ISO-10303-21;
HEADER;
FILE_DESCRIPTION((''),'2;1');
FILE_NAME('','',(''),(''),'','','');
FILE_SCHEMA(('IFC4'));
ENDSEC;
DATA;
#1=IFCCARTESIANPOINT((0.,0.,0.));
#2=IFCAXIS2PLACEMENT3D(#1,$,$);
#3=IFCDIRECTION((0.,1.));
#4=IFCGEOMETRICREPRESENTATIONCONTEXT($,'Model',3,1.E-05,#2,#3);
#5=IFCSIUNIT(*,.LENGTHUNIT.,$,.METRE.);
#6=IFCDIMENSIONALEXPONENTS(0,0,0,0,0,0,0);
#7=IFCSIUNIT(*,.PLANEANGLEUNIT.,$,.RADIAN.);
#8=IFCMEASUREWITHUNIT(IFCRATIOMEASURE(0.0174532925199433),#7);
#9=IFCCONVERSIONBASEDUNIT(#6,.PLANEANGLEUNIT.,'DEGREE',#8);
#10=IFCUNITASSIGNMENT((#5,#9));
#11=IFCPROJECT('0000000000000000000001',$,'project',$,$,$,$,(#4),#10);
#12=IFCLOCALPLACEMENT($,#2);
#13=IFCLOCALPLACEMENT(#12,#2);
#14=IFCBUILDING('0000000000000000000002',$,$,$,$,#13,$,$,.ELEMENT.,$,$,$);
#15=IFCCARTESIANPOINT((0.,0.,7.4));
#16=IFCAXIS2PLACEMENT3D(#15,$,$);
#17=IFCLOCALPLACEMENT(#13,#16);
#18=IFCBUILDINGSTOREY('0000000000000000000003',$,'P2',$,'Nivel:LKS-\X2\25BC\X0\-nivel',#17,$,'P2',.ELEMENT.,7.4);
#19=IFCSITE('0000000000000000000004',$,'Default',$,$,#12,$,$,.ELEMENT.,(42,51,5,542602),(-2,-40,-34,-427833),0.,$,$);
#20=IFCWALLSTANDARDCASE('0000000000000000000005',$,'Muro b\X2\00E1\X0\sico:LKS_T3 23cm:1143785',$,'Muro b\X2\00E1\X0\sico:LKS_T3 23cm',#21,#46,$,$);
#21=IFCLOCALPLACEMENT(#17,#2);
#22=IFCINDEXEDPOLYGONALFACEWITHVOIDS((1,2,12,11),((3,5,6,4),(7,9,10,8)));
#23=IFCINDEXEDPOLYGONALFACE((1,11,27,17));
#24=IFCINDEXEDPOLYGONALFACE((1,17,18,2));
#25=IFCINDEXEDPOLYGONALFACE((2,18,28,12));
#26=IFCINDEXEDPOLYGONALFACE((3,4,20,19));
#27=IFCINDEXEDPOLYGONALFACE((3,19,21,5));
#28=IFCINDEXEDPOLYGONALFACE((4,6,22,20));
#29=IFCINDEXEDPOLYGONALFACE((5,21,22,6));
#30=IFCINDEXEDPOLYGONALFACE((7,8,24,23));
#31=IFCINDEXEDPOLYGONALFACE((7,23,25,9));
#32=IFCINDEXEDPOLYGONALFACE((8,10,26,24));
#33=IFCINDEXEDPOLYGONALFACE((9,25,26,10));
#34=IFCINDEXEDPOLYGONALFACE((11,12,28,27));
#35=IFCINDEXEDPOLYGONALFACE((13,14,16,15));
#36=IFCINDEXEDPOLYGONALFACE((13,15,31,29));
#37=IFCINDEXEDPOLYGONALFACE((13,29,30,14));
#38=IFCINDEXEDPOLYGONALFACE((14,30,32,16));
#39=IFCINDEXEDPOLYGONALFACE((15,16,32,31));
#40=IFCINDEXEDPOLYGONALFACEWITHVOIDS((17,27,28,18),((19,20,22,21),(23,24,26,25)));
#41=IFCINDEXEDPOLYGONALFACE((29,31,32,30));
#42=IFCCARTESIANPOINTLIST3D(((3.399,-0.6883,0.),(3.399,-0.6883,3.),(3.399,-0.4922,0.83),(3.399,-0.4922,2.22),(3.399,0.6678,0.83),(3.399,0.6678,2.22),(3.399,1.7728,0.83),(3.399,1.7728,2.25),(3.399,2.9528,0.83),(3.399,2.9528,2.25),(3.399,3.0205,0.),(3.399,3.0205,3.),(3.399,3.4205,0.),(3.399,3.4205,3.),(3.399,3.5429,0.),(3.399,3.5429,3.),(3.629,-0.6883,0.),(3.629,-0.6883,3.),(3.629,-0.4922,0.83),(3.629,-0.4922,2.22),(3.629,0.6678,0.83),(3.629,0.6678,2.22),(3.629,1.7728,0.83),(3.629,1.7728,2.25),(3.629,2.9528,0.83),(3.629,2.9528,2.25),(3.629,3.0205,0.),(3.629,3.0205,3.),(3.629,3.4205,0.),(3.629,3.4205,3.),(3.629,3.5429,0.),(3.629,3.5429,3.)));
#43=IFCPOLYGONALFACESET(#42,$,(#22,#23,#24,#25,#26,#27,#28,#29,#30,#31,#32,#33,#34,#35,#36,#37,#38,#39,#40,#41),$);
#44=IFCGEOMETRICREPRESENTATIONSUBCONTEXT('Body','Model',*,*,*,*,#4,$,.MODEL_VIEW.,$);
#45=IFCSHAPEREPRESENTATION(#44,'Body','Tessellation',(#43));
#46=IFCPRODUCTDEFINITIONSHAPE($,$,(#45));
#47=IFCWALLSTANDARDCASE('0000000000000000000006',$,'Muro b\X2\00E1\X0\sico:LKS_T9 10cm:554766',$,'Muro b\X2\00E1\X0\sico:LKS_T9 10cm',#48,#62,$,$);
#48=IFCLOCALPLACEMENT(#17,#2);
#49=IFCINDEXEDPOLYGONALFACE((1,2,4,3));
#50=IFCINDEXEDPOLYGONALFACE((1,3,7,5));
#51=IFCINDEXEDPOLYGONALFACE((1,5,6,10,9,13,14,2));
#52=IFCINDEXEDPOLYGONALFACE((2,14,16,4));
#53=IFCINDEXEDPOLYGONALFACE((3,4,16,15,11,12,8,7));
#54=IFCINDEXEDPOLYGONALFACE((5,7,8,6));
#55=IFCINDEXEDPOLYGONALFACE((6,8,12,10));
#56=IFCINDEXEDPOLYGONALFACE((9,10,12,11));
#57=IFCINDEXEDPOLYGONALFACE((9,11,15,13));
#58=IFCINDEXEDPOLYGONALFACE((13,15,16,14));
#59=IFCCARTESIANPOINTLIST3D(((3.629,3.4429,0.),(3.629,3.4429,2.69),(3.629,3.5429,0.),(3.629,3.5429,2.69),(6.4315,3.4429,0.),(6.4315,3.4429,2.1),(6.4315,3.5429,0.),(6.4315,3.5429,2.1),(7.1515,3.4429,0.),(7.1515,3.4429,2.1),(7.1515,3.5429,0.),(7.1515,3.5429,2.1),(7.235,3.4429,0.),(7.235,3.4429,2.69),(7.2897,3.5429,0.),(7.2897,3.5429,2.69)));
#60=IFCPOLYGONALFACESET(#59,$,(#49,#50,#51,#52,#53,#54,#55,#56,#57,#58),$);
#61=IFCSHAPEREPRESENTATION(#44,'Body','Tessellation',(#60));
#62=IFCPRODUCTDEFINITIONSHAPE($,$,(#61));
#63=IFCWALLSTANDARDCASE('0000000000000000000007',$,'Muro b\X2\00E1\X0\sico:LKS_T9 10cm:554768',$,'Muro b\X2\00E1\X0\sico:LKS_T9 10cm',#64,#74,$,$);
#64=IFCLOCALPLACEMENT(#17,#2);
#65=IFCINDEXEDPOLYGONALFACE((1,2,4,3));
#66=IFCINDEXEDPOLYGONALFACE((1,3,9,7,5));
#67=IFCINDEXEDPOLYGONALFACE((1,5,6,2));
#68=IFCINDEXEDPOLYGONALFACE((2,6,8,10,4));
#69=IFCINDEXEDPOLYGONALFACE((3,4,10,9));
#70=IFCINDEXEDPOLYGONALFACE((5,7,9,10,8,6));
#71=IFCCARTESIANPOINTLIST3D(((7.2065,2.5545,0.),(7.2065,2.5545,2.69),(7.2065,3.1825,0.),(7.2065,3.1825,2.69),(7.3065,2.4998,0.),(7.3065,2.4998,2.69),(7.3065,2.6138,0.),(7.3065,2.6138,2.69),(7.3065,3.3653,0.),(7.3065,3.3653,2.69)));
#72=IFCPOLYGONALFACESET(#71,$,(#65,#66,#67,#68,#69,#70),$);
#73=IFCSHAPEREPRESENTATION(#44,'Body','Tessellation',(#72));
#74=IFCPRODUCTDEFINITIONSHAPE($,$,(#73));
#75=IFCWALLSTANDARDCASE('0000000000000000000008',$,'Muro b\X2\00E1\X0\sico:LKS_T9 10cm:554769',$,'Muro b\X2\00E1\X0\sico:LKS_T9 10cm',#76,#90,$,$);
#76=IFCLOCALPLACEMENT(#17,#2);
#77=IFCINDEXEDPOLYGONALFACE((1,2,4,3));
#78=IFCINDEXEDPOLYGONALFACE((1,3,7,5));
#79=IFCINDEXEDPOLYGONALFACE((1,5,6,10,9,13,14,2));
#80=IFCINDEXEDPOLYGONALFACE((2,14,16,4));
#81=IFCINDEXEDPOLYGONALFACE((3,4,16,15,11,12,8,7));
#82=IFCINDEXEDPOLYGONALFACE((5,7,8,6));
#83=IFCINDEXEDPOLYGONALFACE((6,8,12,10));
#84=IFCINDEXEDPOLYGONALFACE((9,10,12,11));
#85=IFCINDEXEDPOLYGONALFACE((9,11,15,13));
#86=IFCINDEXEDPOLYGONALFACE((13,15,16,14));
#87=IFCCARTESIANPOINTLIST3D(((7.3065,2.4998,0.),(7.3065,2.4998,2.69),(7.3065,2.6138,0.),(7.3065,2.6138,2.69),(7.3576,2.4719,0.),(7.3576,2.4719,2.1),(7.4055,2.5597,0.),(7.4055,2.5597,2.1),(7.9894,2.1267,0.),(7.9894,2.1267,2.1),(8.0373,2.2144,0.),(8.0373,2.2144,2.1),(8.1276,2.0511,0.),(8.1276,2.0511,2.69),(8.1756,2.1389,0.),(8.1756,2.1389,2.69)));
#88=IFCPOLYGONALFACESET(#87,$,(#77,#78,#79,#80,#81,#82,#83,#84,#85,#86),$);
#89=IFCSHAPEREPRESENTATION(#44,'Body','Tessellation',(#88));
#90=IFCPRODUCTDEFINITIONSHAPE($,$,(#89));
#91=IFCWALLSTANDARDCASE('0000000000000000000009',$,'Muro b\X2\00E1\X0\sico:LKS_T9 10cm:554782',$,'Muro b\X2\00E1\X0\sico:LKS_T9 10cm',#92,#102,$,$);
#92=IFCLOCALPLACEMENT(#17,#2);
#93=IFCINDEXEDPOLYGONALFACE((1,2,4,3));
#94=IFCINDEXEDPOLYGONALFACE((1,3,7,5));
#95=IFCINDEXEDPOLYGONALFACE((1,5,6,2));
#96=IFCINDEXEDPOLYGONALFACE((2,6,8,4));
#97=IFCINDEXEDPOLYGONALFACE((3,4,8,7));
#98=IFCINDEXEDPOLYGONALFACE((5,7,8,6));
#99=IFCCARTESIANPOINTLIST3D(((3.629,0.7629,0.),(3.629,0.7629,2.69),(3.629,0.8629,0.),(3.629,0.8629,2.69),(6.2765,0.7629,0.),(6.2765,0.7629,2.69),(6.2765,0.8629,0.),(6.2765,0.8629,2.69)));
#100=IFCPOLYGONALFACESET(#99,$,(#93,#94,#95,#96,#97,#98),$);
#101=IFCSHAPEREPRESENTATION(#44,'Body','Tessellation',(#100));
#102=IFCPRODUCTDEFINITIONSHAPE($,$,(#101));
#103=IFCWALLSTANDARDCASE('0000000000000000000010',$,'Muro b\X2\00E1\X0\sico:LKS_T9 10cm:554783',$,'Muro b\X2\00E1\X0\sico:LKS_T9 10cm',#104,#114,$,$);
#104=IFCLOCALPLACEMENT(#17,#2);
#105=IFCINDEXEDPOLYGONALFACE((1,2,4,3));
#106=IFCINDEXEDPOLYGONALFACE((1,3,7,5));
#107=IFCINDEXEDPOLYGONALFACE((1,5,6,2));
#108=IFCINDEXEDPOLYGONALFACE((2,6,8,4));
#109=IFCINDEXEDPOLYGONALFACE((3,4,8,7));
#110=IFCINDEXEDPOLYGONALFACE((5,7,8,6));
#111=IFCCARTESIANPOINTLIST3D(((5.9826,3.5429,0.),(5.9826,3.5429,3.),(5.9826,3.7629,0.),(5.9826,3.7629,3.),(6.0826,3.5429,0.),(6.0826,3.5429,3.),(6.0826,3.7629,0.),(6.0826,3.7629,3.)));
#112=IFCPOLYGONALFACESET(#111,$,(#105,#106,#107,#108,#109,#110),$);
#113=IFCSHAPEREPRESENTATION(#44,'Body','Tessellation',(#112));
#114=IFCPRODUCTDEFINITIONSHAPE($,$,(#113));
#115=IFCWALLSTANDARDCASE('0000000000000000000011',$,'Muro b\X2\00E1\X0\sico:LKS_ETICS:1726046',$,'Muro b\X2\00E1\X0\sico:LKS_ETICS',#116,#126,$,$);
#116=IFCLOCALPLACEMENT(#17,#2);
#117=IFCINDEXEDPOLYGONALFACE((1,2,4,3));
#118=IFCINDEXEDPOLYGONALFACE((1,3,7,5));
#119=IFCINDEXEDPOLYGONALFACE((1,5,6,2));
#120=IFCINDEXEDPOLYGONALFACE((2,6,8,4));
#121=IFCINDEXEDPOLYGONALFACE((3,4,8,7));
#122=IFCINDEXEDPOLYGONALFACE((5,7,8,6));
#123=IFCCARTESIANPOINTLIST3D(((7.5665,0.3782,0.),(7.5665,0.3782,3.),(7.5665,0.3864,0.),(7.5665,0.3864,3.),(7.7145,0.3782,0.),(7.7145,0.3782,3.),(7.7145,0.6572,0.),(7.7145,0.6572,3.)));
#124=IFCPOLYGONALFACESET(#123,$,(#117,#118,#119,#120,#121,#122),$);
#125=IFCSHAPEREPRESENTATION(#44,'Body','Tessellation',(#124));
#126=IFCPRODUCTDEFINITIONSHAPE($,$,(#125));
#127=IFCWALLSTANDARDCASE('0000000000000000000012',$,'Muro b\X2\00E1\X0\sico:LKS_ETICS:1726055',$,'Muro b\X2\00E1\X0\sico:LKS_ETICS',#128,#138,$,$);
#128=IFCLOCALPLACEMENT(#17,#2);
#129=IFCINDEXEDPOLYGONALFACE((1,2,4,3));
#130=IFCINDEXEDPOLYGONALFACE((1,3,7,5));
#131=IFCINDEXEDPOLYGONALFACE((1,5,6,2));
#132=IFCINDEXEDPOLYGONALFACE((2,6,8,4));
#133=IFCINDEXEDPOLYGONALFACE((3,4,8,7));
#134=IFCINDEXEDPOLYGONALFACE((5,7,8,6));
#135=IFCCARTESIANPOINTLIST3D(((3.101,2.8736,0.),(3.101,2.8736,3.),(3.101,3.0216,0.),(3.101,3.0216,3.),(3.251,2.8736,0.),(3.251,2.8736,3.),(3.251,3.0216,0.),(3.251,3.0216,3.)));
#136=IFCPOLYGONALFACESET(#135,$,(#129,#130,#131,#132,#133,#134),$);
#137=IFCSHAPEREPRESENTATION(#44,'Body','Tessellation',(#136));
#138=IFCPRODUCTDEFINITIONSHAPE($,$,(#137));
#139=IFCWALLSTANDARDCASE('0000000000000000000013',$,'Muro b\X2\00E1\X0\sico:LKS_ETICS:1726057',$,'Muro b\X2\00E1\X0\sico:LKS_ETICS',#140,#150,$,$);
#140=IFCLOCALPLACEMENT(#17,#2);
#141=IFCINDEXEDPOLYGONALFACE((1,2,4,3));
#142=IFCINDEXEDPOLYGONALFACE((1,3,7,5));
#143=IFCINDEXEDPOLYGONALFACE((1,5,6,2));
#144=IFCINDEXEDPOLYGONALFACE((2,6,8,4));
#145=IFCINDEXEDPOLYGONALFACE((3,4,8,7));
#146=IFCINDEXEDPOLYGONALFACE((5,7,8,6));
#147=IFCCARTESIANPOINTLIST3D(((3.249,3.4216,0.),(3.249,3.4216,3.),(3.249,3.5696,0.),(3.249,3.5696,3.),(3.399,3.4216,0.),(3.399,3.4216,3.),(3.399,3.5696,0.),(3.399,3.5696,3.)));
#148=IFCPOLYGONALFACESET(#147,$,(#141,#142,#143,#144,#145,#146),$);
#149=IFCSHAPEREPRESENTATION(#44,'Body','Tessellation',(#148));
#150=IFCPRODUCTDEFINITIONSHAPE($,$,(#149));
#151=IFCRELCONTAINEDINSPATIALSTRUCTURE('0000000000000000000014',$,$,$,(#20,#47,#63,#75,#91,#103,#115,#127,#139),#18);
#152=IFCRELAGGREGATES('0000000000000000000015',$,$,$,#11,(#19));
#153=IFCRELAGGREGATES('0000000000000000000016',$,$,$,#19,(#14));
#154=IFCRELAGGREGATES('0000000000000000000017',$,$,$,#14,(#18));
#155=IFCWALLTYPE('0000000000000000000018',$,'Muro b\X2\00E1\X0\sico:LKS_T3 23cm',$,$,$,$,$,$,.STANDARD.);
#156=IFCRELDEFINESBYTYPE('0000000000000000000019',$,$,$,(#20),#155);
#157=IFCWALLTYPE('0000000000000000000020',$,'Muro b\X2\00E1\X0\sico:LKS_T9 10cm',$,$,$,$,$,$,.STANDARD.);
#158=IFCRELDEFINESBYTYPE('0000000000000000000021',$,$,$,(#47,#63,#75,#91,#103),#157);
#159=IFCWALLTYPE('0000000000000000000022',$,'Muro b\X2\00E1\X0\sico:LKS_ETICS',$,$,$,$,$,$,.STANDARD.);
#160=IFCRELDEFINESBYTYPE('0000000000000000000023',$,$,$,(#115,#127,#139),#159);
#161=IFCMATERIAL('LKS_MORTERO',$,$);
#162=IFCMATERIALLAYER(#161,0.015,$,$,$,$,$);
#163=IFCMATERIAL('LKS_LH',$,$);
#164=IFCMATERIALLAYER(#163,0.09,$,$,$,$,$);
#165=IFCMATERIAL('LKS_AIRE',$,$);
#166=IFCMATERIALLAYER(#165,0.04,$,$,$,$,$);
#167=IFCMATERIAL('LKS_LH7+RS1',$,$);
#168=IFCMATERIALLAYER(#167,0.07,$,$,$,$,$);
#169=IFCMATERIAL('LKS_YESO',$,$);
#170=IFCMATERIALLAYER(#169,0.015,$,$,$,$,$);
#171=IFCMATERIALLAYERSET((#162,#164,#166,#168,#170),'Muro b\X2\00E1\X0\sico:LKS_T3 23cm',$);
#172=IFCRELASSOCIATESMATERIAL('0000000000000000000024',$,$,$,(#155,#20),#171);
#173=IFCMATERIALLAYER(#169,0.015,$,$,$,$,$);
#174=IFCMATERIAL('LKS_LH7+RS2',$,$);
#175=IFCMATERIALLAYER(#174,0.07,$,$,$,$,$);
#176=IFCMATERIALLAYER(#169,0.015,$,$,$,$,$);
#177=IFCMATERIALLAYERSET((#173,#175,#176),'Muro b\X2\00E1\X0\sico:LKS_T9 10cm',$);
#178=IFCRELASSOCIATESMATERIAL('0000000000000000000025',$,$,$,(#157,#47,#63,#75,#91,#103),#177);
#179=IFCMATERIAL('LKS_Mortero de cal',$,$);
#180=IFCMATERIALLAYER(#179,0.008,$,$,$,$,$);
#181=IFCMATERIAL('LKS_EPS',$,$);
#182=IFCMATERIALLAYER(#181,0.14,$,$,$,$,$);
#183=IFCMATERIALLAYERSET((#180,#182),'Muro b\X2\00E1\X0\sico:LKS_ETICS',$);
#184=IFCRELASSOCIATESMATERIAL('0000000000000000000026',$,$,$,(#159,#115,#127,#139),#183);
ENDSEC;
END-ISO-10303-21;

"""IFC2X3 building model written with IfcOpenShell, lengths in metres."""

from ifc_helpers import new_model, entity, si_unit, converted_unit, direction, frame, frame_2d, origin, place, context, subcontext, project, spatial, polyline, rectangle, outline, extrude, material, layer, layer_set, layer_usage, type_object, element, save


model = new_model("IFC2X3")

# Units and contexts
model_context = context("Model", 3, precision=1e-05, world=origin(), true_north=direction((0.0, 1.0)))
body_context = subcontext(model_context, "Body", "Model", "MODEL_VIEW")
ifc_project = project(units=[si_unit("LENGTHUNIT", "METRE"), converted_unit("PLANEANGLEUNIT", "DEGREE", entity("IfcRatioMeasure", 0.0174532925199433), si_unit("PLANEANGLEUNIT", "RADIAN"), dimensions=[0, 0, 0, 0, 0, 0, 0])], contexts=[model_context])

# Site, building, storey
site_placement = place(None, origin())
site = spatial("IfcSite", under=ifc_project, at=site_placement, Name="Default", CompositionType="ELEMENT", RefLatitude=(42, 51, 5, 542602), RefLongitude=(-2, -40, -34, -427833), RefElevation=0.0)
building_placement = place(site_placement, origin())
building = spatial("IfcBuilding", under=site, at=building_placement, CompositionType="ELEMENT")
storey_placement = place(building_placement, frame((0.0, 0.0, 7.4)))
storey = spatial("IfcBuildingStorey", under=building, at=storey_placement, Name="P2", ObjectType="Nivel:LKS-▼-nivel", LongName="P2", CompositionType="ELEMENT", Elevation=7.4)

# Shared definitions
ifc_material_1 = material(Name="LKS_MORTERO")

# Wall, openings
ifc_layer_1 = layer(ifc_material_1, 0.015)
ifc_material_2 = material(Name="LKS_LH")
ifc_layer_2 = layer(ifc_material_2, 0.09)
ifc_material_3 = material(Name="LKS_AIRE")
ifc_layer_3 = layer(ifc_material_3, 0.04)
ifc_material_4 = material(Name="LKS_LH7+RS1")
ifc_layer_4 = layer(ifc_material_4, 0.07)
ifc_material_5 = material(Name="LKS_YESO")
ifc_layer_5 = layer(ifc_material_5, 0.015)
ifc_layer_set_1 = layer_set([ifc_layer_1, ifc_layer_2, ifc_layer_3, ifc_layer_4, ifc_layer_5], Name="Muro básico:LKS_T3 23cm")
ifc_layer_usage_1 = layer_usage(ifc_layer_set_1, "AXIS2", "POSITIVE", -0.115)
wall_type_1 = type_object("IfcWallType", Name="Muro básico:LKS_T3 23cm", PredefinedType="STANDARD", material=ifc_layer_set_1)
wall_1_placement = place(storey_placement, frame((3.514, 3.5429, 0.0), z_axis=(0.0, 0.0, 1.0), x_axis=(0.0, -1.0, 0.0)))
wall_1 = element("IfcWallStandardCase", 1, at=wall_1_placement, inside=storey, type_object=wall_type_1, material=ifc_layer_usage_1, Name="Muro básico:LKS_T3 23cm:1143785", ObjectType="Muro básico:LKS_T3 23cm", context=body_context, shape_type="SweptSolid", body=[
    extrude(rectangle(XDim=4.2311, YDim=0.23, at=frame_2d((2.1156, 0.0), x_axis=(-1.0, 0.0))), origin(), (0.0, 0.0, 1.0), 3.0),
])
opening_1_placement = place(storey_placement, frame((3.514, 3.5429, 0.0), z_axis=(0.0, 0.0, 1.0), x_axis=(0.0, -1.0, 0.0)))
element("IfcOpeningElement", 2, at=opening_1_placement, cuts=wall_1, ObjectType="Opening", context=body_context, shape_type="SweptSolid", body=[
    extrude(rectangle(XDim=3.0, YDim=0.23, at=frame_2d((-0.3, 0.013), x_axis=(1.0, 0.0))), frame((0.5224, -0.013, 1.8), z_axis=(-1.0, 0.0, 0.0), x_axis=(0.0, 0.0, 1.0)), (0.0, 0.0, 1.0), 0.4),
])
opening_2_placement = place(wall_1_placement, frame((4.0351, 0.115, 0.83)))
element("IfcOpeningElement", 3, at=opening_2_placement, cuts=wall_1, ObjectType="Opening", context=body_context, shape_type="SweptSolid", body=[
    extrude(rectangle(XDim=1.39, YDim=1.16, at=frame_2d((0.695, 0.58), x_axis=(1.0, 0.0))), frame((0.0, 0.0, 0.0), z_axis=(0.0, -1.0, 0.0), x_axis=(0.0, 0.0, 1.0)), (0.0, 0.0, 1.0), 0.23),
])
opening_3_placement = place(wall_1_placement, frame((0.5901, -0.115, 0.83)))
element("IfcOpeningElement", 4, at=opening_3_placement, cuts=wall_1, ObjectType="Opening", context=body_context, shape_type="SweptSolid", body=[
    extrude(rectangle(XDim=1.42, YDim=1.18, at=frame_2d((0.71, 0.59), x_axis=(1.0, 0.0))), frame((0.0, 0.0, 0.0), z_axis=(0.0, 1.0, 0.0), x_axis=(0.0, 0.0, 1.0)), (0.0, 0.0, 1.0), 0.23),
])

# Wall, opening
ifc_layer_6 = layer(ifc_material_5, 0.015)
ifc_material_6 = material(Name="LKS_LH7+RS2")
ifc_layer_7 = layer(ifc_material_6, 0.07)
ifc_layer_8 = layer(ifc_material_5, 0.015)
ifc_layer_set_2 = layer_set([ifc_layer_6, ifc_layer_7, ifc_layer_8], Name="Muro básico:LKS_T9 10cm")
ifc_layer_usage_2 = layer_usage(ifc_layer_set_2, "AXIS2", "NEGATIVE", 0.05)
wall_type_2 = type_object("IfcWallType", Name="Muro básico:LKS_T9 10cm", PredefinedType="STANDARD", material=ifc_layer_set_2)
wall_2_placement = place(storey_placement, frame((7.2897, 3.4929, 0.0), z_axis=(0.0, 0.0, 1.0), x_axis=(-1.0, 0.0, 0.0)))
wall_2 = element("IfcWallStandardCase", 5, at=wall_2_placement, inside=storey, type_object=wall_type_2, material=ifc_layer_usage_2, Name="Muro básico:LKS_T9 10cm:554766", ObjectType="Muro básico:LKS_T9 10cm", context=body_context, shape_type="SweptSolid", body=[
    extrude(outline(polyline([(0.0, -0.05), (3.6608, -0.05), (3.6608, 0.05), (1.0132, 0.05), (0.9132, 0.05), (0.0547, 0.05), (0.0, -0.05)])), origin(), (0.0, 0.0, 1.0), 2.69),
])
opening_4_placement = place(wall_2_placement, frame((0.8582, 0.05, 0.0)))
element("IfcOpeningElement", 6, at=opening_4_placement, cuts=wall_2, ObjectType="Opening", context=body_context, shape_type="SweptSolid", body=[
    extrude(rectangle(XDim=2.1, YDim=0.72, at=frame_2d((1.05, 0.36), x_axis=(1.0, 0.0))), frame((0.0, 0.0, 0.0), z_axis=(0.0, -1.0, 0.0), x_axis=(0.0, 0.0, 1.0)), (0.0, 0.0, 1.0), 0.1),
])

# Wall
ifc_layer_usage_3 = layer_usage(ifc_layer_set_2, "AXIS2", "NEGATIVE", 0.05)
wall_3_placement = place(storey_placement, frame((7.2565, 3.3653, 0.0), z_axis=(0.0, 0.0, 1.0), x_axis=(0.0, -1.0, 0.0)))
element("IfcWallStandardCase", 7, at=wall_3_placement, inside=storey, type_object=wall_type_2, material=ifc_layer_usage_3, Name="Muro básico:LKS_T9 10cm:554768", ObjectType="Muro básico:LKS_T9 10cm", context=body_context, shape_type="SweptSolid", body=[
    extrude(outline(polyline([(0.8108, -0.05), (0.8655, 0.05), (0.7515, 0.05), (0.0, 0.05), (0.1828, -0.05), (0.8108, -0.05)])), origin(), (0.0, 0.0, 1.0), 2.69),
])

# Wall, opening
ifc_layer_usage_4 = layer_usage(ifc_layer_set_2, "AXIS2", "NEGATIVE", 0.05)
wall_4_placement = place(storey_placement, frame((7.2826, 2.5699, 0.0), z_axis=(0.0, 0.0, 1.0), x_axis=(0.877509, -0.479561, 0.0)))
wall_4 = element("IfcWallStandardCase", 8, at=wall_4_placement, inside=storey, type_object=wall_type_2, material=ifc_layer_usage_4, Name="Muro básico:LKS_T9 10cm:554769", ObjectType="Muro básico:LKS_T9 10cm", context=body_context, shape_type="SweptSolid", body=[
    extrude(outline(polyline([(0.0547, -0.05), (0.9903, -0.05), (0.9903, 0.05), (0.0, 0.05), (0.0547, -0.05)])), origin(), (0.0, 0.0, 1.0), 2.69),
])
opening_5_placement = place(wall_4_placement, frame((0.1128, -0.05, 0.0)))
element("IfcOpeningElement", 9, at=opening_5_placement, cuts=wall_4, ObjectType="Opening", context=body_context, shape_type="SweptSolid", body=[
    extrude(rectangle(XDim=2.1, YDim=0.72, at=frame_2d((1.05, 0.36), x_axis=(1.0, 0.0))), frame((0.0, 0.0, 0.0), z_axis=(0.0, 1.0, 0.0), x_axis=(0.0, 0.0, 1.0)), (0.0, 0.0, 1.0), 0.1),
])

# Walls
ifc_layer_usage_5 = layer_usage(ifc_layer_set_2, "AXIS2", "NEGATIVE", 0.05)
wall_5_placement = place(storey_placement, frame((6.2765, 0.8129, 0.0), z_axis=(0.0, 0.0, 1.0), x_axis=(-1.0, 0.0, 0.0)))
element("IfcWallStandardCase", 10, at=wall_5_placement, inside=storey, type_object=wall_type_2, material=ifc_layer_usage_5, Name="Muro básico:LKS_T9 10cm:554782", ObjectType="Muro básico:LKS_T9 10cm", context=body_context, shape_type="SweptSolid", body=[
    extrude(rectangle(XDim=2.6476, YDim=0.1, at=frame_2d((1.3238, 0.0), x_axis=(-1.0, 0.0))), origin(), (0.0, 0.0, 1.0), 2.69),
])
ifc_layer_usage_6 = layer_usage(ifc_layer_set_2, "AXIS2", "NEGATIVE", 0.05)
wall_6_placement = place(storey_placement, frame((6.0326, 3.5429, 0.0), z_axis=(0.0, 0.0, 1.0), x_axis=(0.0, 1.0, 0.0)))
element("IfcWallStandardCase", 11, at=wall_6_placement, inside=storey, type_object=wall_type_2, material=ifc_layer_usage_6, Name="Muro básico:LKS_T9 10cm:554783", ObjectType="Muro básico:LKS_T9 10cm", context=body_context, shape_type="SweptSolid", body=[
    extrude(rectangle(XDim=0.22, YDim=0.1, at=frame_2d((0.11, 0.0), x_axis=(-1.0, 0.0))), origin(), (0.0, 0.0, 1.0), 3.0),
])
ifc_material_7 = material(Name="LKS_Mortero de cal")
ifc_layer_9 = layer(ifc_material_7, 0.008)
ifc_material_8 = material(Name="LKS_EPS")
ifc_layer_10 = layer(ifc_material_8, 0.14)
ifc_layer_set_3 = layer_set([ifc_layer_9, ifc_layer_10], Name="Muro básico:LKS_ETICS")
ifc_layer_usage_7 = layer_usage(ifc_layer_set_3, "AXIS2", "NEGATIVE", 0.074)
wall_type_3 = type_object("IfcWallType", Name="Muro básico:LKS_ETICS", PredefinedType="STANDARD", material=ifc_layer_set_3)
wall_7_placement = place(storey_placement, frame((7.6405, 0.6572, 0.0), z_axis=(0.0, 0.0, 1.0), x_axis=(0.0, -1.0, 0.0)))
element("IfcWallStandardCase", 12, at=wall_7_placement, inside=storey, type_object=wall_type_3, material=ifc_layer_usage_7, Name="Muro básico:LKS_ETICS:1726046", ObjectType="Muro básico:LKS_ETICS", context=body_context, shape_type="SweptSolid", body=[
    extrude(outline(polyline([(0.279, -0.074), (0.279, 0.074), (0.0, 0.074), (0.2708, -0.074), (0.279, -0.074)])), origin(), (0.0, 0.0, 1.0), 3.0),
])
ifc_layer_usage_8 = layer_usage(ifc_layer_set_3, "AXIS2", "NEGATIVE", 0.074)
wall_8_placement = place(storey_placement, frame((3.251, 2.9476, 0.0), z_axis=(0.0, 0.0, 1.0), x_axis=(-1.0, 0.0, 0.0)))
element("IfcWallStandardCase", 13, at=wall_8_placement, inside=storey, type_object=wall_type_3, material=ifc_layer_usage_8, Name="Muro básico:LKS_ETICS:1726055", ObjectType="Muro básico:LKS_ETICS", context=body_context, shape_type="SweptSolid", body=[
    extrude(rectangle(XDim=0.15, YDim=0.148, at=frame_2d((0.075, 0.0), x_axis=(-1.0, 0.0))), origin(), (0.0, 0.0, 1.0), 3.0),
])
ifc_layer_usage_9 = layer_usage(ifc_layer_set_3, "AXIS2", "NEGATIVE", 0.074)
wall_9_placement = place(storey_placement, frame((3.249, 3.4956, 0.0)))
element("IfcWallStandardCase", 14, at=wall_9_placement, inside=storey, type_object=wall_type_3, material=ifc_layer_usage_9, Name="Muro básico:LKS_ETICS:1726057", ObjectType="Muro básico:LKS_ETICS", context=body_context, shape_type="SweptSolid", body=[
    extrude(rectangle(XDim=0.15, YDim=0.148, at=frame_2d((0.075, 0.0), x_axis=(-1.0, 0.0))), origin(), (0.0, 0.0, 1.0), 3.0),
])

save(model, "model.ifc")
